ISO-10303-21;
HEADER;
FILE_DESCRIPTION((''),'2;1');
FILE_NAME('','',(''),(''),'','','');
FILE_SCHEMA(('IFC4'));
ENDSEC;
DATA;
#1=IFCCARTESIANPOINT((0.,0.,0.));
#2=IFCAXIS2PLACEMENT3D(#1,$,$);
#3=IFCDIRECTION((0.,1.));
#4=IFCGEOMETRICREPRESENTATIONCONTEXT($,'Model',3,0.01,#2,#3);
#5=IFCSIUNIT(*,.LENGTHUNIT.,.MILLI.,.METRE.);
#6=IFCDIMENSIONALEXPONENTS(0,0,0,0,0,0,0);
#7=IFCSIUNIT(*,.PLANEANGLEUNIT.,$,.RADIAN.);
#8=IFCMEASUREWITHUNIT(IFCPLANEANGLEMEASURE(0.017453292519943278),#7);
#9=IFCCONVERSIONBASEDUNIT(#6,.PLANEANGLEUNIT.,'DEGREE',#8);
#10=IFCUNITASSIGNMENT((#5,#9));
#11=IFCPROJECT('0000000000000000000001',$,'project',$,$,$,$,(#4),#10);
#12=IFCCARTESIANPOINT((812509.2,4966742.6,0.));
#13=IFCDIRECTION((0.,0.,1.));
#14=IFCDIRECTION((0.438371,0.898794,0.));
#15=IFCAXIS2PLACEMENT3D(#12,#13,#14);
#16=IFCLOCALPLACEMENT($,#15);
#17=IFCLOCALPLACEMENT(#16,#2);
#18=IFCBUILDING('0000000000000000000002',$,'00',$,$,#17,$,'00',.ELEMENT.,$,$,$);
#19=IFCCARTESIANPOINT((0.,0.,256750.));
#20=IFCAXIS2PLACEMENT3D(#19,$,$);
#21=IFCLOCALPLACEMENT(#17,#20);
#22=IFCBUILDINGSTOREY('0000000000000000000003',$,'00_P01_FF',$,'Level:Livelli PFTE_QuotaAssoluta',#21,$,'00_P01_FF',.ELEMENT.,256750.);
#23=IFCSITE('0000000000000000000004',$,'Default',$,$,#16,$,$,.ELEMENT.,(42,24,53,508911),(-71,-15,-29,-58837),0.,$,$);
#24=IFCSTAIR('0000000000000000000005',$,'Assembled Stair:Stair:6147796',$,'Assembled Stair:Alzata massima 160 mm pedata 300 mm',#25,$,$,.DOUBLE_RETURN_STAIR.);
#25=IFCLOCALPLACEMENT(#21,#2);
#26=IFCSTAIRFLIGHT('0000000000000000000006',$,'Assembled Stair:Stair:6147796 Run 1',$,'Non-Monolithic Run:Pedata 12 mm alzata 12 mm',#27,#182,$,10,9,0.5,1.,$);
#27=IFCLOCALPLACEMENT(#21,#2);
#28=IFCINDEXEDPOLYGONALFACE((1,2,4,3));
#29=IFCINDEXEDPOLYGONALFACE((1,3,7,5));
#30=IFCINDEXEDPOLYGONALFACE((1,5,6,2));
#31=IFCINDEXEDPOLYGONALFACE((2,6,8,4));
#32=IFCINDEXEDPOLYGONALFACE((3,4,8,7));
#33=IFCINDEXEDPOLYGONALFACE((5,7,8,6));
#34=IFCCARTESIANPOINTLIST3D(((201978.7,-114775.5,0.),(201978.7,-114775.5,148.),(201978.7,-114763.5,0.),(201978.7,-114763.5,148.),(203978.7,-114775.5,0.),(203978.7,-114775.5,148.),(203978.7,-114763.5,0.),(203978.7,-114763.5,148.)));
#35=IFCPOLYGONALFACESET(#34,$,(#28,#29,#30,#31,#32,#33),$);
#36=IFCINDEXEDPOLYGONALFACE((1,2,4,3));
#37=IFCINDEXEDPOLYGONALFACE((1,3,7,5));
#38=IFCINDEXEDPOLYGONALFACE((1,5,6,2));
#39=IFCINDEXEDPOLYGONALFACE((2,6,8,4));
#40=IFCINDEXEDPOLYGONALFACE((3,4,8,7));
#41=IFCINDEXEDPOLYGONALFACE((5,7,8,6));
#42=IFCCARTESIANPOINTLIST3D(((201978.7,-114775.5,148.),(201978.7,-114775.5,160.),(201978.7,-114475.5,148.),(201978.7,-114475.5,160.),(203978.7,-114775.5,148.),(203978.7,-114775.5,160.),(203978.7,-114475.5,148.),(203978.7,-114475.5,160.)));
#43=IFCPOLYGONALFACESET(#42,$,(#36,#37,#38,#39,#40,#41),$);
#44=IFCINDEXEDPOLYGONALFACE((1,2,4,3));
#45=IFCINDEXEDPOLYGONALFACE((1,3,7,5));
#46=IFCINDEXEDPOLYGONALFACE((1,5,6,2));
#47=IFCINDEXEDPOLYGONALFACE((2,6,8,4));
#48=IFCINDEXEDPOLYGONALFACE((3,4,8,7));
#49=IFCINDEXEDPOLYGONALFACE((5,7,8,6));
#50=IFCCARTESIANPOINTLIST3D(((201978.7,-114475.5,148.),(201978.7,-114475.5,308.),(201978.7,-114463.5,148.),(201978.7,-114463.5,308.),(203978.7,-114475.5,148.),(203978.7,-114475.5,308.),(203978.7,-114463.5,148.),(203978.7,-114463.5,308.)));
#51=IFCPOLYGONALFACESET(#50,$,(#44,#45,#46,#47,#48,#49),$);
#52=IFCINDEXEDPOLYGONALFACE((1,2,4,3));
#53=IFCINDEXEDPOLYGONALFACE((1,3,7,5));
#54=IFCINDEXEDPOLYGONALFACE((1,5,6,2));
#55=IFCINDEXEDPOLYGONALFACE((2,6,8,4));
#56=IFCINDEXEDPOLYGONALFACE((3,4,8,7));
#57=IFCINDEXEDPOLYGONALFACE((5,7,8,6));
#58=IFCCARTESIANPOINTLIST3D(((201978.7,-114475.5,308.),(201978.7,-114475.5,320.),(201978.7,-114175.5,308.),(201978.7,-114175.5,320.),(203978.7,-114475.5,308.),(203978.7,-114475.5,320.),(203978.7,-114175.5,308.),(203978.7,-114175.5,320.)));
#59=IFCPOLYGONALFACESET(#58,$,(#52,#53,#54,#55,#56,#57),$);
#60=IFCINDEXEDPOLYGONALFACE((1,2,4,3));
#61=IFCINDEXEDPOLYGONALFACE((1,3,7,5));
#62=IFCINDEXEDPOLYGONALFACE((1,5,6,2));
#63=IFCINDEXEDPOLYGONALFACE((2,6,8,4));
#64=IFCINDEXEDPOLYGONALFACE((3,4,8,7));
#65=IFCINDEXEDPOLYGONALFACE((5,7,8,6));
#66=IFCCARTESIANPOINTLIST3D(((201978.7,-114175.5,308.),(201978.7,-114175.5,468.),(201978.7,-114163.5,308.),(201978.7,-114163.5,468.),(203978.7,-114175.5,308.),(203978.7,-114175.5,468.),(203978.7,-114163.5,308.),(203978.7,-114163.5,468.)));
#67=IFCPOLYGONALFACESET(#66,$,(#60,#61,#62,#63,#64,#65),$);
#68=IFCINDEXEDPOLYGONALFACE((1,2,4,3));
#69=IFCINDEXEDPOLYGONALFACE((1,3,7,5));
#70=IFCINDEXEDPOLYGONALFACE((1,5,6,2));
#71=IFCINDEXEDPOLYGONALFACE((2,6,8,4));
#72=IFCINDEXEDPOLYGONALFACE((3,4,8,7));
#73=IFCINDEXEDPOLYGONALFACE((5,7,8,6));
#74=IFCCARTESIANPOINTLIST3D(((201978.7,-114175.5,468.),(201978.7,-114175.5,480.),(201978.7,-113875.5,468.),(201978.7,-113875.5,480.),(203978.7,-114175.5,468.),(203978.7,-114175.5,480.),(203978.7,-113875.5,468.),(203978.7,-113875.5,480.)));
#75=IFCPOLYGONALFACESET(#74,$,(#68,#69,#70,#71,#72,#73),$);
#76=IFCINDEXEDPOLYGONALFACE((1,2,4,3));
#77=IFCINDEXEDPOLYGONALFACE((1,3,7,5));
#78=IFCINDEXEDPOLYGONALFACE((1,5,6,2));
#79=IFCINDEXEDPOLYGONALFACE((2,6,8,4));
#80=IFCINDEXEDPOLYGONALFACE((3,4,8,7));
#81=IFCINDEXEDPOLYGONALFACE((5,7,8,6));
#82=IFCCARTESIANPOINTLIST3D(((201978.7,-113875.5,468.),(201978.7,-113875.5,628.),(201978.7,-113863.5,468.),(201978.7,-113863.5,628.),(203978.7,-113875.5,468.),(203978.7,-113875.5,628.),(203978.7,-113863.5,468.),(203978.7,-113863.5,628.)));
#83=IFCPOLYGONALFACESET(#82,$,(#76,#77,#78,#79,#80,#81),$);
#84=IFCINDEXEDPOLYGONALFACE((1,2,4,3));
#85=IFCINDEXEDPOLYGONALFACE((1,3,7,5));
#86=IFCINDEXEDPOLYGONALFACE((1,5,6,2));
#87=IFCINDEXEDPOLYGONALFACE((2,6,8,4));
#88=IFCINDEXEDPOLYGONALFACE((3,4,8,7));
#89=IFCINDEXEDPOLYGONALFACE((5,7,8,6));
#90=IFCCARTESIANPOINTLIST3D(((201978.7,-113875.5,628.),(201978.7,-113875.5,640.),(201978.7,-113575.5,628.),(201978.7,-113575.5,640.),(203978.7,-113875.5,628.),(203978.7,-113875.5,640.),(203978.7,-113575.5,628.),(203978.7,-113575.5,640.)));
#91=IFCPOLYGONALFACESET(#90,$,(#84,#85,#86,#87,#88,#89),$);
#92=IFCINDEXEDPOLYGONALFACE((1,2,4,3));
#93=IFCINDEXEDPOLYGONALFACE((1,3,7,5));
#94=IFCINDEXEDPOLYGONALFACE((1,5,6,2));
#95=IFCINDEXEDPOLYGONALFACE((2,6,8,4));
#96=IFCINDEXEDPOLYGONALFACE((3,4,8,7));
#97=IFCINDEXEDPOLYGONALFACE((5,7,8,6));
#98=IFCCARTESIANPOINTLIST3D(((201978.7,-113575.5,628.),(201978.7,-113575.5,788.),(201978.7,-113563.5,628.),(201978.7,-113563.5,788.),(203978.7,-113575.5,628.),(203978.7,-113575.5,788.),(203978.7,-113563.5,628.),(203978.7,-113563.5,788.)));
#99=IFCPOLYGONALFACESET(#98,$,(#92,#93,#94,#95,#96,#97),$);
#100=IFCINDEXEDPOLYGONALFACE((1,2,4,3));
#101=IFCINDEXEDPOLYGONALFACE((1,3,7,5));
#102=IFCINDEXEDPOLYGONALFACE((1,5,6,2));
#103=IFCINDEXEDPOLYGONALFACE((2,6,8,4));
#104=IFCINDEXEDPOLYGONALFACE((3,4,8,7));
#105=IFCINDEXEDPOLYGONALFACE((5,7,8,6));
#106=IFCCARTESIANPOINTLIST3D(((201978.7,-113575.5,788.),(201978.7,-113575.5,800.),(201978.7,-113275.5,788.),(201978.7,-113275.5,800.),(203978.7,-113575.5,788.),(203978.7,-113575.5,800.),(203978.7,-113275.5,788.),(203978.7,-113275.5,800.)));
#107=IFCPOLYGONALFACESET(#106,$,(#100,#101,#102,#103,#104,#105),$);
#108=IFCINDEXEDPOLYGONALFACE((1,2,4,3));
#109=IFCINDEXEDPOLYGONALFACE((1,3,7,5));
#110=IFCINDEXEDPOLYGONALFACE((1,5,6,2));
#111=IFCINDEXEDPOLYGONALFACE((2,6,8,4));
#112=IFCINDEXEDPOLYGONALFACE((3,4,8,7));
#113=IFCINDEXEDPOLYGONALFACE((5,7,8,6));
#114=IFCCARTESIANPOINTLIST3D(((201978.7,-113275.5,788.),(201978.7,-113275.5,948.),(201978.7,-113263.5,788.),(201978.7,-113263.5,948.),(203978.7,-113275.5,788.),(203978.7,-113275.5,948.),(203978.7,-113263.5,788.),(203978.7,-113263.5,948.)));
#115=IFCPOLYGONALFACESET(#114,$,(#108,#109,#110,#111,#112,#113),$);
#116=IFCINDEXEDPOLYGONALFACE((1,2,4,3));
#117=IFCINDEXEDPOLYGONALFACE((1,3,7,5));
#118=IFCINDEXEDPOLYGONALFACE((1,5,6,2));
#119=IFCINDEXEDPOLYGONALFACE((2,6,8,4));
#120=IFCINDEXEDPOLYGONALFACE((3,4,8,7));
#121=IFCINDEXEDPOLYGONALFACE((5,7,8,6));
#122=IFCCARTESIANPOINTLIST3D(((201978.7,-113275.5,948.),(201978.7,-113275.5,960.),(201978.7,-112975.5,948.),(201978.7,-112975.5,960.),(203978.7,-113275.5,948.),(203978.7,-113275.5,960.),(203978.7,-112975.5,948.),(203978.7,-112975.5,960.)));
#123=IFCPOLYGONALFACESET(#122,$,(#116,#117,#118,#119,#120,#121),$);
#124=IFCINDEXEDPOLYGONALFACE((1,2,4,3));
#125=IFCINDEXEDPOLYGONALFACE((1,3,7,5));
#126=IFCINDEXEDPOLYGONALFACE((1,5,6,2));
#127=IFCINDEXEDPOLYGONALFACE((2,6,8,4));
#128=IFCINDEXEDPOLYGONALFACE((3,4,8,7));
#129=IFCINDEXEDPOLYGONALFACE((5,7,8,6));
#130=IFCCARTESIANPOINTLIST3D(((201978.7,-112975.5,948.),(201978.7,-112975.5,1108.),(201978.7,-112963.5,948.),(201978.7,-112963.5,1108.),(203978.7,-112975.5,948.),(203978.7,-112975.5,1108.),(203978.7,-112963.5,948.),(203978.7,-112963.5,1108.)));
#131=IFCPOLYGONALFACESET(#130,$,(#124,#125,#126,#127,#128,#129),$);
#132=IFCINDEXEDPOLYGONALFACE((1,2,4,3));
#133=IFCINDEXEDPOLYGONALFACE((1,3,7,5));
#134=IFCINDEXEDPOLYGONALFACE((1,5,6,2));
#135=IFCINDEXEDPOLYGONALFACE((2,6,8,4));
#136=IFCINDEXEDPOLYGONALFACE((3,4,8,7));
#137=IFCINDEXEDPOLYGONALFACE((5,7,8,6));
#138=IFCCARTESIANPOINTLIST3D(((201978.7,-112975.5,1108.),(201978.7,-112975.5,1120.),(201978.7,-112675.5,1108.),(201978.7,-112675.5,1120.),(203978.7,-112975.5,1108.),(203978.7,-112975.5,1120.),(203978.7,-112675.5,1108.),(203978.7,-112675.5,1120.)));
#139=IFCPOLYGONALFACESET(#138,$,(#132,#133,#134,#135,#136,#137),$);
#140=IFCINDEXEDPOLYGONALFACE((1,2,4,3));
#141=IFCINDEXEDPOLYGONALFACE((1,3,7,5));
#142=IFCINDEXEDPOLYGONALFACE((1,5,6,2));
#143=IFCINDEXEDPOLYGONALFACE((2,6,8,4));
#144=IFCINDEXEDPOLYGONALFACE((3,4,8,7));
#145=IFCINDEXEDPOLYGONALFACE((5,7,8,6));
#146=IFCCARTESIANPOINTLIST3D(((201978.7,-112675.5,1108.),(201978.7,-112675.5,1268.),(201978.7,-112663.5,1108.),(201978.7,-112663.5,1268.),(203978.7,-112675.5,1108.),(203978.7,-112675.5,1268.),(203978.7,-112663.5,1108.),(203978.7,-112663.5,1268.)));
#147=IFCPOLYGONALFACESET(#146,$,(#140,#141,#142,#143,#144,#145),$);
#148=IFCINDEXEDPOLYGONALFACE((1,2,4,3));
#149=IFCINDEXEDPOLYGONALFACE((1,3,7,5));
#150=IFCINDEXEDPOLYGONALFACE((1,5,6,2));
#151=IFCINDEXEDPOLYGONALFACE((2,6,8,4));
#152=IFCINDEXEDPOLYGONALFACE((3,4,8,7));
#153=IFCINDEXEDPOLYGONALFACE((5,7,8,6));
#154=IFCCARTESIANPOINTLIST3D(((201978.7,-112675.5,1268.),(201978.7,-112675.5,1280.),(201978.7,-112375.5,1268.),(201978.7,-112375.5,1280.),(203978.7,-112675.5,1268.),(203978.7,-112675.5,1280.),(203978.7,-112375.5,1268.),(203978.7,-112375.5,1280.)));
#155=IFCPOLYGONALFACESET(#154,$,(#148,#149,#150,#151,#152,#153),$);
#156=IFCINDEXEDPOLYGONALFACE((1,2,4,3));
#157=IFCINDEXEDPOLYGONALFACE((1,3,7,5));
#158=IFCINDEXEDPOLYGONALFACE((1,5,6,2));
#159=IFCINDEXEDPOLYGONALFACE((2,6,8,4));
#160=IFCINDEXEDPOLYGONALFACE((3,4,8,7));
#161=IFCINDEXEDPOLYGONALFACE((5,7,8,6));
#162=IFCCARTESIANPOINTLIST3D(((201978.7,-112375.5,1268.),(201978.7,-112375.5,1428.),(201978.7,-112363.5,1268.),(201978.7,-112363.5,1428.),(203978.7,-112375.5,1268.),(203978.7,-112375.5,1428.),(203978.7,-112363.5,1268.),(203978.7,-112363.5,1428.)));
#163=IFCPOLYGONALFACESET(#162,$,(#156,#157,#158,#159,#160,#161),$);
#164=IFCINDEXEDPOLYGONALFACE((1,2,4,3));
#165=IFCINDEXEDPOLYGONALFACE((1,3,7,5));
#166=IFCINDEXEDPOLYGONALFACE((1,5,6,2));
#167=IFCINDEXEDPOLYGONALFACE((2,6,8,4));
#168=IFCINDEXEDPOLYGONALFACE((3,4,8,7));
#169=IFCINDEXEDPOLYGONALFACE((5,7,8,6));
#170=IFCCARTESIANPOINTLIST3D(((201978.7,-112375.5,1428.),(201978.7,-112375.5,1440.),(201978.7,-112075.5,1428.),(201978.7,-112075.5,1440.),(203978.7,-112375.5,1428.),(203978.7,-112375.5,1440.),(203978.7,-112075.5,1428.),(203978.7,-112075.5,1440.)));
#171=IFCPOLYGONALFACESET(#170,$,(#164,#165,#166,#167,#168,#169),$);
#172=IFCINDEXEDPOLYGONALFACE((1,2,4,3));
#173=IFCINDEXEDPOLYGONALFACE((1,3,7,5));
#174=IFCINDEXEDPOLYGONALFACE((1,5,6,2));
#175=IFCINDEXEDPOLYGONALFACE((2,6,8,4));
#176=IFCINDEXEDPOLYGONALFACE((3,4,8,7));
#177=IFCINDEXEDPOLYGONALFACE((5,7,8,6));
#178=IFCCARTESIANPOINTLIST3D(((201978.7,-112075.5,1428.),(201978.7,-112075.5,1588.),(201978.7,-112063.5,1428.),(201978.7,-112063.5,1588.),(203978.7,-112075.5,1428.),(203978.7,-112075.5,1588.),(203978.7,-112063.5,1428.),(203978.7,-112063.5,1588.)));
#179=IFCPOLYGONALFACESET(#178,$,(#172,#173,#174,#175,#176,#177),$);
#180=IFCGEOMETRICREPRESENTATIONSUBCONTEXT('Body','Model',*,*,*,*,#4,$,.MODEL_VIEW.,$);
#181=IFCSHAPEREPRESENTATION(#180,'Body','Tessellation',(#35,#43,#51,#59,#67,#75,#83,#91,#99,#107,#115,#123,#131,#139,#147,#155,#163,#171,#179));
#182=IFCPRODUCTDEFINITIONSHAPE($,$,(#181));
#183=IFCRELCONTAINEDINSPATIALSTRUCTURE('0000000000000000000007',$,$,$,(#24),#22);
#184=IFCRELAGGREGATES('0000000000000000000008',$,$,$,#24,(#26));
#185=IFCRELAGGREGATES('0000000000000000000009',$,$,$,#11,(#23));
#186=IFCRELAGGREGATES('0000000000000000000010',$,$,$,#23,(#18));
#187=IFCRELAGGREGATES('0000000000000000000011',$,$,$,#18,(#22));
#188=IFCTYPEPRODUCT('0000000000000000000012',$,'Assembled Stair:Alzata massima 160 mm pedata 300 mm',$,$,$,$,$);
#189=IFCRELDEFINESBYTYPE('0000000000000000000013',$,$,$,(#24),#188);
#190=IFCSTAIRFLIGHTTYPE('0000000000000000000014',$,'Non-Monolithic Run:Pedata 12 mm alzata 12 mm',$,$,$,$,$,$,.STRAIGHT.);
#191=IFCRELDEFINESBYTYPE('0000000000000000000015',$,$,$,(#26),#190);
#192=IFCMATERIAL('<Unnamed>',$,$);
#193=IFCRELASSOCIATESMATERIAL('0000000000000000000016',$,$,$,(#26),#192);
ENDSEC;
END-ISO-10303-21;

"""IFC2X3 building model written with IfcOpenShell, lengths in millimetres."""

from ifc_helpers import new_model, entity, si_unit, converted_unit, direction, frame, frame_2d, origin, origin_2d_with_axis, place, context, subcontext, project, spatial, rectangle, extrude, material, type_object, element, aggregate, save


model = new_model("IFC2X3")

# Units and contexts
model_context = context("Model", 3, precision=0.01, world=origin(), true_north=direction((0.0, 1.0)))
body_context = subcontext(model_context, "Body", "Model", "MODEL_VIEW")
ifc_project = project(units=[si_unit("LENGTHUNIT", "METRE", prefix="MILLI"), converted_unit("PLANEANGLEUNIT", "DEGREE", entity("IfcPlaneAngleMeasure", 0.017453292519943278), si_unit("PLANEANGLEUNIT", "RADIAN"), dimensions=[0, 0, 0, 0, 0, 0, 0])], contexts=[model_context])

# Site, building, storey
site_placement = place(None, frame((812509.2, 4966742.6, 0.0), z_axis=(0.0, 0.0, 1.0), x_axis=(0.438371, 0.898794, 0.0)))
site = spatial("IfcSite", under=ifc_project, at=site_placement, Name="Default", CompositionType="ELEMENT", RefLatitude=(42, 24, 53, 508911), RefLongitude=(-71, -15, -29, -58837), RefElevation=0.0)
building_placement = place(site_placement, origin())
building = spatial("IfcBuilding", under=site, at=building_placement, Name="00", LongName="00", CompositionType="ELEMENT")
storey_placement = place(building_placement, frame((0.0, 0.0, 256750.0)))
storey = spatial("IfcBuildingStorey", under=building, at=storey_placement, Name="00_P01_FF", ObjectType="Level:Livelli PFTE_QuotaAssoluta", LongName="00_P01_FF", CompositionType="ELEMENT", Elevation=256750.0)

# Stair
type_product = type_object("IfcTypeProduct", Name="Assembled Stair:Alzata massima 160 mm pedata 300 mm")
ifc_material = material(Name="<Unnamed>")
stair_1_placement = place(storey_placement, origin())
stair_1 = element("IfcStair", 1, at=stair_1_placement, inside=storey, type_object=type_product, Name="Assembled Stair:Stair:6147796", ObjectType="Assembled Stair:Alzata massima 160 mm pedata 300 mm", ShapeType="DOUBLE_RETURN_STAIR")

# Stair flight
stair_flight_type = type_object("IfcStairFlightType", Name="Non-Monolithic Run:Pedata 12 mm alzata 12 mm", PredefinedType="STRAIGHT")
stair_flight_1_placement = place(stair_1_placement, origin())
stair_flight_1 = element("IfcStairFlight", 2, at=stair_flight_1_placement, type_object=stair_flight_type, material=ifc_material, Name="Assembled Stair:Stair:6147796 Run 1", ObjectType="Non-Monolithic Run:Pedata 12 mm alzata 12 mm", NumberOfRiser=10, NumberOfTreads=9, RiserHeight=0.5, TreadLength=1.0, context=body_context, shape_type="SweptSolid", body=[
    extrude(rectangle(XDim=2000.0, YDim=12.0, at=origin_2d_with_axis()), frame((202978.7, -114769.5, 0.0), z_axis=(0.0, 0.0, 1.0), x_axis=(-1.0, 0.0, 0.0)), (0.0, 0.0, 1.0), 148.0),
    extrude(rectangle(XDim=300.0, YDim=2000.0, at=frame_2d((0.0, 0.0), x_axis=(1.0, 0.0))), frame((202978.7, -114625.5, 148.0), z_axis=(0.0, 0.0, 1.0), x_axis=(0.0, -1.0, 0.0)), (0.0, 0.0, 1.0), 12.0),
    extrude(rectangle(XDim=2000.0, YDim=12.0, at=frame_2d((0.0, 0.0), x_axis=(1.0, 0.0))), frame((202978.7, -114469.5, 148.0), z_axis=(0.0, 0.0, 1.0), x_axis=(-1.0, 0.0, 0.0)), (0.0, 0.0, 1.0), 160.0),
    extrude(rectangle(XDim=300.0, YDim=2000.0, at=frame_2d((0.0, 0.0), x_axis=(1.0, 0.0))), frame((202978.7, -114325.5, 308.0), z_axis=(0.0, 0.0, 1.0), x_axis=(0.0, -1.0, 0.0)), (0.0, 0.0, 1.0), 12.0),
    extrude(rectangle(XDim=2000.0, YDim=12.0, at=frame_2d((0.0, 0.0), x_axis=(1.0, 0.0))), frame((202978.7, -114169.5, 308.0), z_axis=(0.0, 0.0, 1.0), x_axis=(-1.0, 0.0, 0.0)), (0.0, 0.0, 1.0), 160.0),
    extrude(rectangle(XDim=300.0, YDim=2000.0, at=frame_2d((0.0, 0.0), x_axis=(1.0, 0.0))), frame((202978.7, -114025.5, 468.0), z_axis=(0.0, 0.0, 1.0), x_axis=(0.0, -1.0, 0.0)), (0.0, 0.0, 1.0), 12.0),
    extrude(rectangle(XDim=2000.0, YDim=12.0, at=frame_2d((0.0, 0.0), x_axis=(1.0, 0.0))), frame((202978.7, -113869.5, 468.0), z_axis=(0.0, 0.0, 1.0), x_axis=(-1.0, 0.0, 0.0)), (0.0, 0.0, 1.0), 160.0),
    extrude(rectangle(XDim=300.0, YDim=2000.0, at=frame_2d((0.0, 0.0), x_axis=(1.0, 0.0))), frame((202978.7, -113725.5, 628.0), z_axis=(0.0, 0.0, 1.0), x_axis=(0.0, -1.0, 0.0)), (0.0, 0.0, 1.0), 12.0),
    extrude(rectangle(XDim=2000.0, YDim=12.0, at=frame_2d((0.0, 0.0), x_axis=(1.0, 0.0))), frame((202978.7, -113569.5, 628.0), z_axis=(0.0, 0.0, 1.0), x_axis=(-1.0, 0.0, 0.0)), (0.0, 0.0, 1.0), 160.0),
    extrude(rectangle(XDim=300.0, YDim=2000.0, at=frame_2d((0.0, 0.0), x_axis=(1.0, 0.0))), frame((202978.7, -113425.5, 788.0), z_axis=(0.0, 0.0, 1.0), x_axis=(0.0, -1.0, 0.0)), (0.0, 0.0, 1.0), 12.0),
    extrude(rectangle(XDim=2000.0, YDim=12.0, at=frame_2d((0.0, 0.0), x_axis=(1.0, 0.0))), frame((202978.7, -113269.5, 788.0), z_axis=(0.0, 0.0, 1.0), x_axis=(-1.0, 0.0, 0.0)), (0.0, 0.0, 1.0), 160.0),
    extrude(rectangle(XDim=300.0, YDim=2000.0, at=frame_2d((0.0, 0.0), x_axis=(1.0, 0.0))), frame((202978.7, -113125.5, 948.0), z_axis=(0.0, 0.0, 1.0), x_axis=(0.0, -1.0, 0.0)), (0.0, 0.0, 1.0), 12.0),
    extrude(rectangle(XDim=2000.0, YDim=12.0, at=frame_2d((0.0, 0.0), x_axis=(1.0, 0.0))), frame((202978.7, -112969.5, 948.0), z_axis=(0.0, 0.0, 1.0), x_axis=(-1.0, 0.0, 0.0)), (0.0, 0.0, 1.0), 160.0),
    extrude(rectangle(XDim=300.0, YDim=2000.0, at=frame_2d((0.0, 0.0), x_axis=(1.0, 0.0))), frame((202978.7, -112825.5, 1108.0), z_axis=(0.0, 0.0, 1.0), x_axis=(0.0, -1.0, 0.0)), (0.0, 0.0, 1.0), 12.0),
    extrude(rectangle(XDim=2000.0, YDim=12.0, at=frame_2d((0.0, 0.0), x_axis=(1.0, 0.0))), frame((202978.7, -112669.5, 1108.0), z_axis=(0.0, 0.0, 1.0), x_axis=(-1.0, 0.0, 0.0)), (0.0, 0.0, 1.0), 160.0),
    extrude(rectangle(XDim=300.0, YDim=2000.0, at=frame_2d((0.0, 0.0), x_axis=(1.0, 0.0))), frame((202978.7, -112525.5, 1268.0), z_axis=(0.0, 0.0, 1.0), x_axis=(0.0, -1.0, 0.0)), (0.0, 0.0, 1.0), 12.0),
    extrude(rectangle(XDim=2000.0, YDim=12.0, at=frame_2d((0.0, 0.0), x_axis=(1.0, 0.0))), frame((202978.7, -112369.5, 1268.0), z_axis=(0.0, 0.0, 1.0), x_axis=(-1.0, 0.0, 0.0)), (0.0, 0.0, 1.0), 160.0),
    extrude(rectangle(XDim=300.0, YDim=2000.0, at=frame_2d((0.0, 0.0), x_axis=(1.0, 0.0))), frame((202978.7, -112225.5, 1428.0), z_axis=(0.0, 0.0, 1.0), x_axis=(0.0, -1.0, 0.0)), (0.0, 0.0, 1.0), 12.0),
    extrude(rectangle(XDim=2000.0, YDim=12.0, at=origin_2d_with_axis()), frame((202978.7, -112069.5, 1428.0), z_axis=(0.0, 0.0, 1.0), x_axis=(-1.0, 0.0, 0.0)), (0.0, 0.0, 1.0), 160.0),
])
aggregate(stair_1, [stair_flight_1])

save(model, "model.ifc")
